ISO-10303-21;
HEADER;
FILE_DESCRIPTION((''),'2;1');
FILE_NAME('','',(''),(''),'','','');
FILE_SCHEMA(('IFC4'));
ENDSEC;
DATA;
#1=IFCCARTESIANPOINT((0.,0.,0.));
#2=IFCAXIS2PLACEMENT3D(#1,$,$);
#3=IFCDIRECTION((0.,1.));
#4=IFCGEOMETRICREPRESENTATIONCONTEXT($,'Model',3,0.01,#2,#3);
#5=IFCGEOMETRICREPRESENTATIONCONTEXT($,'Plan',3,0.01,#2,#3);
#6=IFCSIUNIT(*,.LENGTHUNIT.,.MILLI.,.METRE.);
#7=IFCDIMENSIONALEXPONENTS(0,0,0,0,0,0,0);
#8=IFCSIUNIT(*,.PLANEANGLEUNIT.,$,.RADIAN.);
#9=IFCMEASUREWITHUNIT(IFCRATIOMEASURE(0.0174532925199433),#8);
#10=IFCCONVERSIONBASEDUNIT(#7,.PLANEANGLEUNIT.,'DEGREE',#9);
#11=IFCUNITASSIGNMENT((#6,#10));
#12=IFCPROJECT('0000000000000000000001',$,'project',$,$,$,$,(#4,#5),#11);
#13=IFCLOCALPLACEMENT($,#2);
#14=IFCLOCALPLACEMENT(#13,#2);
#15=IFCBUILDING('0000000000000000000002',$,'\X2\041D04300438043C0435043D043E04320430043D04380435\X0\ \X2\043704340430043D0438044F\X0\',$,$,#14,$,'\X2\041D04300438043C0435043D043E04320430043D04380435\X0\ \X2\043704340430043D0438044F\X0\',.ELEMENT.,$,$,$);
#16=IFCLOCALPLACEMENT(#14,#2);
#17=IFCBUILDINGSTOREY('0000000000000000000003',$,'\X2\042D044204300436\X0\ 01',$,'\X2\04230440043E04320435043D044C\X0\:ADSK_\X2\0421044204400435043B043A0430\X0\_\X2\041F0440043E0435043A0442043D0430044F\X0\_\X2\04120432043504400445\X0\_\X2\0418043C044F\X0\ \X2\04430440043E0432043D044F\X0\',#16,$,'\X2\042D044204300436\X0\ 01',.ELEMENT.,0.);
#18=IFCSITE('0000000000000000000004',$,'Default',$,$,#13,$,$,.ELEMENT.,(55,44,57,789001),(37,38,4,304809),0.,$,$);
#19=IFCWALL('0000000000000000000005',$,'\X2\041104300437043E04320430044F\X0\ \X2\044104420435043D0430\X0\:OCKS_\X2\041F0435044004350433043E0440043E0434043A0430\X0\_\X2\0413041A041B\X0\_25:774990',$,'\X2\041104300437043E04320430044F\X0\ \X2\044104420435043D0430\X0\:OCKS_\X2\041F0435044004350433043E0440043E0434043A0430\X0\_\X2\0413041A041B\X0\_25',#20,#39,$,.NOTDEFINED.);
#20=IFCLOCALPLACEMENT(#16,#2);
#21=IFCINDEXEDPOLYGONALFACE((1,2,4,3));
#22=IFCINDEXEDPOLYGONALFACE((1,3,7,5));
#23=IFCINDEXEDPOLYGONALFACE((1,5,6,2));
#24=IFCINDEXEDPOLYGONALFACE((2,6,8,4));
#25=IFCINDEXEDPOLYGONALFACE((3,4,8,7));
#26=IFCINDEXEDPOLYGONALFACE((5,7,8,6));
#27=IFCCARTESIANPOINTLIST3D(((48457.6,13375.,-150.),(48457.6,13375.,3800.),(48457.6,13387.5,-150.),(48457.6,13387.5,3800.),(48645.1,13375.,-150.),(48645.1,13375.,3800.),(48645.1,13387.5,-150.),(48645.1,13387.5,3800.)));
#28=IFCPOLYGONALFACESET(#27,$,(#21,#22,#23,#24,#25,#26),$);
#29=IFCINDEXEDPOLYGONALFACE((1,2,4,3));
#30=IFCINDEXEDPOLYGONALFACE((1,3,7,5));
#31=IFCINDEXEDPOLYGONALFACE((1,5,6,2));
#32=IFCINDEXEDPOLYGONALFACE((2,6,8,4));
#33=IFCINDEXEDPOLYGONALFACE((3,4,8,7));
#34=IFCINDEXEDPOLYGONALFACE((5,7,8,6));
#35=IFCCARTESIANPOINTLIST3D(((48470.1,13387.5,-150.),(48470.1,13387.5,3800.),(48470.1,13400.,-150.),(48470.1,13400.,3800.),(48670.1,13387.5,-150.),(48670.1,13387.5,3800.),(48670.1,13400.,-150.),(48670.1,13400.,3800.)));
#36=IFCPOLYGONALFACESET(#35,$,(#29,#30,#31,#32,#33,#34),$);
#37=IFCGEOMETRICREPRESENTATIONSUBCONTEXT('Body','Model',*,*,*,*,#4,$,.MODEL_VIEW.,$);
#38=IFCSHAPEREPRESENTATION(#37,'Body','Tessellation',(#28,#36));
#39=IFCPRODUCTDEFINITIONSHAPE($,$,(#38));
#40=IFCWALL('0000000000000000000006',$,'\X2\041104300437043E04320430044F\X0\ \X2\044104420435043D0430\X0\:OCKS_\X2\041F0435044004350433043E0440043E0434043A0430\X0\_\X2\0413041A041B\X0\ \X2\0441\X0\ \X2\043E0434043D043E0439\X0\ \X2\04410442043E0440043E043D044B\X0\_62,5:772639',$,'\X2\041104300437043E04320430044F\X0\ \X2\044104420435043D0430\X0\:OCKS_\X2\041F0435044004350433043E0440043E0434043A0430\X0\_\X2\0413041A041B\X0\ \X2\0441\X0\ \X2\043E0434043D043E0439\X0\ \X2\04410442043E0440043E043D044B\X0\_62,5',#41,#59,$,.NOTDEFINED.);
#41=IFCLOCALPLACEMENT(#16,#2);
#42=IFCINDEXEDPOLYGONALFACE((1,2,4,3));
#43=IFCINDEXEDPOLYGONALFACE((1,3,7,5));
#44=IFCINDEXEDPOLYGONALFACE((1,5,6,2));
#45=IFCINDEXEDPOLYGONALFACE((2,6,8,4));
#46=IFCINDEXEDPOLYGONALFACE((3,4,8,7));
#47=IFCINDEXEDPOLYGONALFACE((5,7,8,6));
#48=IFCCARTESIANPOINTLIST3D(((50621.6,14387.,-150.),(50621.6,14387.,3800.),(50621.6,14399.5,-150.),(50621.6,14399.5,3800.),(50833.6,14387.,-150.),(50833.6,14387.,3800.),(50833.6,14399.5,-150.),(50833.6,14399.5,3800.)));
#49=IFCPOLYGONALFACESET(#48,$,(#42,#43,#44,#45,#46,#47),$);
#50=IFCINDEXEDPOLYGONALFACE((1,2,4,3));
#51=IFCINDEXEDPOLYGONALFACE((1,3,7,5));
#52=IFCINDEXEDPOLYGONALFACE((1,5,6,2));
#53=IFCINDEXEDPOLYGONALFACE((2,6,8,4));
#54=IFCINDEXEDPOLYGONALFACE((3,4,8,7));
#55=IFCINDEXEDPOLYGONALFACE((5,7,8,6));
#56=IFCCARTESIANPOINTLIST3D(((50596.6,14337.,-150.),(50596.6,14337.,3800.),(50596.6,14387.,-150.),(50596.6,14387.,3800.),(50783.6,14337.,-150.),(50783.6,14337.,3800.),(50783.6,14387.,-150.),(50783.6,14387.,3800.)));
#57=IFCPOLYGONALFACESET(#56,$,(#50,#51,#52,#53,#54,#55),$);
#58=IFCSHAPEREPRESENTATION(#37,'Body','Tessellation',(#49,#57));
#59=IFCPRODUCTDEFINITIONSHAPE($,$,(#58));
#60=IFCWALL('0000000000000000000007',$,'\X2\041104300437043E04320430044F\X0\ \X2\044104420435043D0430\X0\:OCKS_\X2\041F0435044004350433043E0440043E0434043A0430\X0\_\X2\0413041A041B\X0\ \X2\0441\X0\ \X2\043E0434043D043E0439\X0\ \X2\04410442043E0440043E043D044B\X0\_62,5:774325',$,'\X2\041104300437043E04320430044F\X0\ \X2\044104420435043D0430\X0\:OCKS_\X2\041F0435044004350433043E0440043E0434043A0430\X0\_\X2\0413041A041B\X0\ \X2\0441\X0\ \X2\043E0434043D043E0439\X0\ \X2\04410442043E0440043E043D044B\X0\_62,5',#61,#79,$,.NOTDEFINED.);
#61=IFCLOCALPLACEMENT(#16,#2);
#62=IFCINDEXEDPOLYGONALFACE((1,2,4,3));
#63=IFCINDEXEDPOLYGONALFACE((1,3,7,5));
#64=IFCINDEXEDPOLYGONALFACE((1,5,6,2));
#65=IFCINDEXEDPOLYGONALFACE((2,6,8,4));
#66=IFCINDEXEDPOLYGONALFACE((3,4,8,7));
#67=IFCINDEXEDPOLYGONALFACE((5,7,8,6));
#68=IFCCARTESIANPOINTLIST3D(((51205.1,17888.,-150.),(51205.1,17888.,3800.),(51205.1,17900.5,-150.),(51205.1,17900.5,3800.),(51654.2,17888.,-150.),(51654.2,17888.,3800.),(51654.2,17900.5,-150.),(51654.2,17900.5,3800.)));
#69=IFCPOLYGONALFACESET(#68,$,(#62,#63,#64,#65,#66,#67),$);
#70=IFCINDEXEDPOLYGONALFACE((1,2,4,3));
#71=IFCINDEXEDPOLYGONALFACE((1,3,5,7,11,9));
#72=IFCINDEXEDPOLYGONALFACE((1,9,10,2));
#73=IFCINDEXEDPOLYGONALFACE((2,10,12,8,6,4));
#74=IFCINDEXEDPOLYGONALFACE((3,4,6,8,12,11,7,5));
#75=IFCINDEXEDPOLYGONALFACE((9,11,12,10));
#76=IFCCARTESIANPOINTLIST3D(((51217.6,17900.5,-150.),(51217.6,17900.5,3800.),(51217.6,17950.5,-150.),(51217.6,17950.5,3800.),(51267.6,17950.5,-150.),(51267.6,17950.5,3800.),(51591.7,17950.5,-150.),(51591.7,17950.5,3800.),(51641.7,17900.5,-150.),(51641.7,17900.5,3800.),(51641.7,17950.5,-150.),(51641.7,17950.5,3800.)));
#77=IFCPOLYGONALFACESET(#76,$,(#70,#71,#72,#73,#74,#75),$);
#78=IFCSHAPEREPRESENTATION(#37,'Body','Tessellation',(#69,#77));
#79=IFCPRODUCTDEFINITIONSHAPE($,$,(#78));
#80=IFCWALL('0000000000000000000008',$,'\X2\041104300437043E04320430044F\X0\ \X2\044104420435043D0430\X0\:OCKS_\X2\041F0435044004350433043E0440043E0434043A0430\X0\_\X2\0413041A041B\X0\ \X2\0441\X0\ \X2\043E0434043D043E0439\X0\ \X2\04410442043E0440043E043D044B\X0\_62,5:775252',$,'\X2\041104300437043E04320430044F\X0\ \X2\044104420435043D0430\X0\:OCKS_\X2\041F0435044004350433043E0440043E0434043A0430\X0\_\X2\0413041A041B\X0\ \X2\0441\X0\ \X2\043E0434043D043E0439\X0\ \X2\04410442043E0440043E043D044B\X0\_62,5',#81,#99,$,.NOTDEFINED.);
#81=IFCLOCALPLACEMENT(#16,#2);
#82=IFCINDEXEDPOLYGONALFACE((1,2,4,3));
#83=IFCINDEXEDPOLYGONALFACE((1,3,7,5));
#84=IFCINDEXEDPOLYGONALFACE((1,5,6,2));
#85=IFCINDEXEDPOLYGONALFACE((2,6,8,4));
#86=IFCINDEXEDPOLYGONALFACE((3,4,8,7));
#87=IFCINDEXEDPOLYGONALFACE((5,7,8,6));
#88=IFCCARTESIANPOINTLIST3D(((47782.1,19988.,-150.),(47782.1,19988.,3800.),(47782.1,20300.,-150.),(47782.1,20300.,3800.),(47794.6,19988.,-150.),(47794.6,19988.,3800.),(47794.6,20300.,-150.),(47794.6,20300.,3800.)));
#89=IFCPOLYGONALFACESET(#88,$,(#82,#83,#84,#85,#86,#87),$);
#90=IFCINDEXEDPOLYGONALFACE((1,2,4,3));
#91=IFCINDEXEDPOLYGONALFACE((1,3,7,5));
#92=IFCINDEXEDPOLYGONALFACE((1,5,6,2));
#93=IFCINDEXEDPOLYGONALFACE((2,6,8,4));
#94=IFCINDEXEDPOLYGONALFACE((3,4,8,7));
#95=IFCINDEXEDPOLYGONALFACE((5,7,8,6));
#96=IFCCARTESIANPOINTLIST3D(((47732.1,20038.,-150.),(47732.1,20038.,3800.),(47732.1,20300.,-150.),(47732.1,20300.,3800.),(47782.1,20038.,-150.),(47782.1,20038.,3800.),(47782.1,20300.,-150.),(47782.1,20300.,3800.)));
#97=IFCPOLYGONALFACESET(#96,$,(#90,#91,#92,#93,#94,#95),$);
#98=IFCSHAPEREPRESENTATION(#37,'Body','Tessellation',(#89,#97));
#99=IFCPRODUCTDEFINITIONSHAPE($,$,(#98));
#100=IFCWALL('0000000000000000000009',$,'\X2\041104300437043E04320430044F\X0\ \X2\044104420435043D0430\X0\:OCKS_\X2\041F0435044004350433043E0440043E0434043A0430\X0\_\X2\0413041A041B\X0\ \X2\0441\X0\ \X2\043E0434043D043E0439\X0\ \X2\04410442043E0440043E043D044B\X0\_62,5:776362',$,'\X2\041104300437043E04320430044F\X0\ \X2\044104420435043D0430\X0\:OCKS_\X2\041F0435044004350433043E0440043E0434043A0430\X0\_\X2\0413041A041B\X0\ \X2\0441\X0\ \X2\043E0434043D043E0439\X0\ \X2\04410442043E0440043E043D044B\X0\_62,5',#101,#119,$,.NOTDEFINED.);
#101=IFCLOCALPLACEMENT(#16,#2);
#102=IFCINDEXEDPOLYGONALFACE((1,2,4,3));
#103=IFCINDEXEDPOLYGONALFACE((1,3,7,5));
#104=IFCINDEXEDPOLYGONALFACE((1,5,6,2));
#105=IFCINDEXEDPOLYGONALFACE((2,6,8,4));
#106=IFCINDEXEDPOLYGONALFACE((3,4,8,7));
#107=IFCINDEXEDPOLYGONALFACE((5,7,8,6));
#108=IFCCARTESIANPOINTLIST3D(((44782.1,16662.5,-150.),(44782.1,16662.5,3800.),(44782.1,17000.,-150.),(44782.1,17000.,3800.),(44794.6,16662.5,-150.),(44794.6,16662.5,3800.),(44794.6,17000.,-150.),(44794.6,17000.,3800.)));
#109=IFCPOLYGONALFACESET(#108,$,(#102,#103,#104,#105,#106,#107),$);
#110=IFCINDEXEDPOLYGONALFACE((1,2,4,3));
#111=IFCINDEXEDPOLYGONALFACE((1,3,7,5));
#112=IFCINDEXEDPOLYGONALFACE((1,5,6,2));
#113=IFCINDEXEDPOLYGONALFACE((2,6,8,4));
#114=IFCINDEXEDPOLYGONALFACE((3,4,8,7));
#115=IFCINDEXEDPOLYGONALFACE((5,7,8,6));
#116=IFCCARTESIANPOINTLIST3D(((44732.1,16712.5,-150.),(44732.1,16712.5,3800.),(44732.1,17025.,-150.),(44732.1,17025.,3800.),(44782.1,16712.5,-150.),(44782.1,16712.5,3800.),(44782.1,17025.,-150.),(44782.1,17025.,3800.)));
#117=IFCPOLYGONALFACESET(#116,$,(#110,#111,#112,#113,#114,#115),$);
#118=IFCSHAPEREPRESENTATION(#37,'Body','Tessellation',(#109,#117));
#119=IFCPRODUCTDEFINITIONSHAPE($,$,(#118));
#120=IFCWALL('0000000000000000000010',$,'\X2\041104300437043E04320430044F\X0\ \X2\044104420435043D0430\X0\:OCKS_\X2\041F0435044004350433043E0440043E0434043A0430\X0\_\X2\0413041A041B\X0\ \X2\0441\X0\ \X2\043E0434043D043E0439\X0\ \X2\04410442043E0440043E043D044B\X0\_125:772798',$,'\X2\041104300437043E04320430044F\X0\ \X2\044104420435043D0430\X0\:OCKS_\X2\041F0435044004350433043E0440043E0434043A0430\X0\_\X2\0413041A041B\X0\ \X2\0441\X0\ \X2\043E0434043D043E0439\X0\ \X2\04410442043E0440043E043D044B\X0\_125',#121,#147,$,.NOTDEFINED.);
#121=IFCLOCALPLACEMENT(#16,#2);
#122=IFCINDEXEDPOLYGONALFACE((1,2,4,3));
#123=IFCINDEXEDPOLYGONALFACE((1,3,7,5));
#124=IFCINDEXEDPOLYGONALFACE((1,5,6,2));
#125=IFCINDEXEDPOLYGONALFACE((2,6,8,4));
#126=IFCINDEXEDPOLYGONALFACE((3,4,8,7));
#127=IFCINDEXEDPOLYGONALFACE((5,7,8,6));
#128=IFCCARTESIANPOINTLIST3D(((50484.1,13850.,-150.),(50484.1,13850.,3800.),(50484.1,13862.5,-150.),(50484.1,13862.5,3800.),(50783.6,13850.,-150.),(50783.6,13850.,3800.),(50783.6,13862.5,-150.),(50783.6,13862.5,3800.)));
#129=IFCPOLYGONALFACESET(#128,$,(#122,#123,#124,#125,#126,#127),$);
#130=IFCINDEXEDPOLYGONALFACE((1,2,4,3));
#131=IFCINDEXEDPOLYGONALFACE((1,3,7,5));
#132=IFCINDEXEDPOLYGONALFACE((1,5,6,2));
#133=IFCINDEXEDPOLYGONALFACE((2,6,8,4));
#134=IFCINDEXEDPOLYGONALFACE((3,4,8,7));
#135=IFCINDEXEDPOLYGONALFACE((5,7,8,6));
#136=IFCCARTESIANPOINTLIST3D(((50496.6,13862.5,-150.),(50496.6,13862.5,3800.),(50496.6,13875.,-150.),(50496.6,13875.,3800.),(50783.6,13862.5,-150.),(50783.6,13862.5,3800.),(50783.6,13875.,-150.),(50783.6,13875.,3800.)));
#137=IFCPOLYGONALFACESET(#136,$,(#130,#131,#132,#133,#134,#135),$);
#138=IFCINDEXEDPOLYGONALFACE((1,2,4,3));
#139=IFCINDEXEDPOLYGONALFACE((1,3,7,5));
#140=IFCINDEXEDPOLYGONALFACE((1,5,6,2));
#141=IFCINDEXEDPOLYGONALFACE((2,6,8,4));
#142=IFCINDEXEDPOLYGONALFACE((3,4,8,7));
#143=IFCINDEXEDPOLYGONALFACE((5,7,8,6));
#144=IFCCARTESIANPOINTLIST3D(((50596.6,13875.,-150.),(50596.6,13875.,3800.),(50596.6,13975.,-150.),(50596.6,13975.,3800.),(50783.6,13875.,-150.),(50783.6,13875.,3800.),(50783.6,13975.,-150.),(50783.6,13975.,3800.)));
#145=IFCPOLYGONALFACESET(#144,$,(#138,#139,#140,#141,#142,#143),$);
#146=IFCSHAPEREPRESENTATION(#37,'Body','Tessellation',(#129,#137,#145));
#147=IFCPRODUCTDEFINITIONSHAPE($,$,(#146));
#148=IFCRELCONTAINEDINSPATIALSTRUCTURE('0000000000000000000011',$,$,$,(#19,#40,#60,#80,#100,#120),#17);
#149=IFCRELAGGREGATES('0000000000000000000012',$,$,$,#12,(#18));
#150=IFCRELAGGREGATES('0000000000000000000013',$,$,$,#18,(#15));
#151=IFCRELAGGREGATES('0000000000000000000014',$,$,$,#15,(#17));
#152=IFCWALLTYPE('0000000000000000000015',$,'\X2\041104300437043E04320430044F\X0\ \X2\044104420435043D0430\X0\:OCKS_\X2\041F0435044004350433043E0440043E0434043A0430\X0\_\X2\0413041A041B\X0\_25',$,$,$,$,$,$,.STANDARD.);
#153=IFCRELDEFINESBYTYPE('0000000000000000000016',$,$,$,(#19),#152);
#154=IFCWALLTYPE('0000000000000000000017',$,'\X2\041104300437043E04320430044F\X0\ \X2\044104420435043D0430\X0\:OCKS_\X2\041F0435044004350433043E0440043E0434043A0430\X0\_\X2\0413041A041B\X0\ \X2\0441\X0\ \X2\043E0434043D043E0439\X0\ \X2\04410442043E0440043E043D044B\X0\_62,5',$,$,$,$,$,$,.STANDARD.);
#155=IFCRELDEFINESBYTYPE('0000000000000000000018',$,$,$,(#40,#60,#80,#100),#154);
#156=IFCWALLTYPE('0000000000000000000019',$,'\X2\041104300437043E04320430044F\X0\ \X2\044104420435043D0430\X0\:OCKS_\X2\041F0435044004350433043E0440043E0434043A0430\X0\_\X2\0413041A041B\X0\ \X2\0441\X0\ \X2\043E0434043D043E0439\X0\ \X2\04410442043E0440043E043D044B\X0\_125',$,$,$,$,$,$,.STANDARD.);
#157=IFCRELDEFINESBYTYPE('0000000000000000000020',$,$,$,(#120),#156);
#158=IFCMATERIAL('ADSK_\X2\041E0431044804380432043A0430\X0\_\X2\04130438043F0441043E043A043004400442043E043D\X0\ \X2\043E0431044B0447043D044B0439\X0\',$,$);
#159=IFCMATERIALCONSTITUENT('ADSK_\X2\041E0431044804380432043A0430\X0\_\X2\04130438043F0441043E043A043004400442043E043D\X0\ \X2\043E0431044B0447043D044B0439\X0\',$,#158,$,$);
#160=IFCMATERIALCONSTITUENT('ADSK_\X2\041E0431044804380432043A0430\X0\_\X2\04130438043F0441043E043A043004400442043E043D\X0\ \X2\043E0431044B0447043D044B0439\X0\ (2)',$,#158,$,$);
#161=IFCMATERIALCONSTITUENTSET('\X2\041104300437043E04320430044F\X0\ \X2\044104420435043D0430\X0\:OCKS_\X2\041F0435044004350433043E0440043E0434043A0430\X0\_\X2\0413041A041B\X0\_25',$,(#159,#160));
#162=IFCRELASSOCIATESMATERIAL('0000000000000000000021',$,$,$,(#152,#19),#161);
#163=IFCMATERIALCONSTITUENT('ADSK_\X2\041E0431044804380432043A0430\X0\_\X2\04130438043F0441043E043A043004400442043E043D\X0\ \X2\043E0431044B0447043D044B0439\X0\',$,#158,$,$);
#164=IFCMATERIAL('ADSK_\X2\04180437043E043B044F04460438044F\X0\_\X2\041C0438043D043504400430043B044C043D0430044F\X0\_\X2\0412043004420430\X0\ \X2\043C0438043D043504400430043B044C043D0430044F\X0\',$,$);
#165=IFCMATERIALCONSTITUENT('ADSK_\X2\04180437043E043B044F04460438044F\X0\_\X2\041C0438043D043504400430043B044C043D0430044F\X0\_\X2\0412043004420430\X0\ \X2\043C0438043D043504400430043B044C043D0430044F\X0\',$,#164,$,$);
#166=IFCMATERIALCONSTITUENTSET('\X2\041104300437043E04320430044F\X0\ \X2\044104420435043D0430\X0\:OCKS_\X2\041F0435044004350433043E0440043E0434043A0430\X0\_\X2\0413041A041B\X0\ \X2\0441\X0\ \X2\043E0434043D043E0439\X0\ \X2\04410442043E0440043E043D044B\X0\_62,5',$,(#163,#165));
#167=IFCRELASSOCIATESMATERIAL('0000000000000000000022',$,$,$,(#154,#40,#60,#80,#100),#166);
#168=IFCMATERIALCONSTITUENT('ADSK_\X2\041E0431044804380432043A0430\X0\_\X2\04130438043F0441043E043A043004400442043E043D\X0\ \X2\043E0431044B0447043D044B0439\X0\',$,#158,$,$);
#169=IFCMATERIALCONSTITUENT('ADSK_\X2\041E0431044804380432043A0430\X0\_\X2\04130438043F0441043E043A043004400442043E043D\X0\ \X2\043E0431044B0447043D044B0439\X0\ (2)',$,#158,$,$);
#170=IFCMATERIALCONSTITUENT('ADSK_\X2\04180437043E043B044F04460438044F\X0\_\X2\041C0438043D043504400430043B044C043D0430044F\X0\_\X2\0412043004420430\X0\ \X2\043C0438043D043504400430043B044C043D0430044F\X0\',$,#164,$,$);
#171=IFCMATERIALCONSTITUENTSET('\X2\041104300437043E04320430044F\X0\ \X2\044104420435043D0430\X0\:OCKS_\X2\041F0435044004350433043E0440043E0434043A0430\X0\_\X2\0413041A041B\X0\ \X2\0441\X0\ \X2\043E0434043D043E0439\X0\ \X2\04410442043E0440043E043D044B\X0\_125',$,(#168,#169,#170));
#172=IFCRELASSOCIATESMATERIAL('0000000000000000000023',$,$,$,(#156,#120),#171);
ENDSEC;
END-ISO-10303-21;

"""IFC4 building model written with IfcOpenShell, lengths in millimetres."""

from ifc_helpers import new_model, entity, si_unit, converted_unit, direction, frame, origin, place, context, subcontext, project, spatial, indexed_curve, outline, extrude, material, constituent, constituent_set, type_object, element, save


model = new_model("IFC4")

# Units and contexts
model_context = context("Model", 3, precision=0.01, world=origin(), true_north=direction((0.0, 1.0)))
plan_context = context("Plan", 3, precision=0.01, world=origin(), true_north=direction((0.0, 1.0)))
body_context = subcontext(model_context, "Body", "Model", "MODEL_VIEW")
ifc_project = project(units=[si_unit("LENGTHUNIT", "METRE", prefix="MILLI"), converted_unit("PLANEANGLEUNIT", "DEGREE", entity("IfcRatioMeasure", 0.0174532925199433), si_unit("PLANEANGLEUNIT", "RADIAN"), dimensions=[0, 0, 0, 0, 0, 0, 0])], contexts=[model_context, plan_context])

# Site, building, storey
site_placement = place(None, frame((0.0, 0.0, 0.0)))
site = spatial("IfcSite", under=ifc_project, at=site_placement, Name="Default", CompositionType="ELEMENT", RefLatitude=(55, 44, 57, 789001), RefLongitude=(37, 38, 4, 304809), RefElevation=0.0)
building_placement = place(site_placement, origin())
building = spatial("IfcBuilding", under=site, at=building_placement, Name="Наименование здания", LongName="Наименование здания", CompositionType="ELEMENT")
storey_placement = place(building_placement, origin())
storey = spatial("IfcBuildingStorey", under=building, at=storey_placement, Name="Этаж 01", ObjectType="Уровень:ADSK_Стрелка_Проектная_Вверх_Имя уровня", LongName="Этаж 01", CompositionType="ELEMENT", Elevation=0.0)

# Shared definitions
ifc_material_1 = material(Name="ADSK_Обшивка_Гипсокартон обычный")
ifc_material_2 = material(Name="ADSK_Изоляция_Минеральная_Вата минеральная")

# Walls
ifc_constituent_1 = constituent(ifc_material_1, Name="ADSK_Обшивка_Гипсокартон обычный")
ifc_constituent_2 = constituent(ifc_material_1, Name="ADSK_Обшивка_Гипсокартон обычный (2)")
ifc_constituent_set_1 = constituent_set(constituents=[ifc_constituent_1, ifc_constituent_2], Name="Базовая стена:OCKS_Перегородка_ГКЛ_25")
wall_type_1 = type_object("IfcWallType", Name="Базовая стена:OCKS_Перегородка_ГКЛ_25", PredefinedType="STANDARD", material=ifc_constituent_set_1)
wall_1_placement = place(storey_placement, frame((48470.1, 13387.5, -150.0)))
element("IfcWall", 1, at=wall_1_placement, inside=storey, type_object=wall_type_1, material=ifc_constituent_set_1, Name="Базовая стена:OCKS_Перегородка_ГКЛ_25:774990", ObjectType="Базовая стена:OCKS_Перегородка_ГКЛ_25", PredefinedType="NOTDEFINED", context=body_context, shape_type="SweptSolid", body=[
    extrude(outline(indexed_curve([(-6.3, -93.8), (6.3, -93.8), (6.3, 93.8), (-6.3, 93.8), (-6.3, -93.8)], self_intersect=False)), frame((81.3, -6.3, 0.0), z_axis=(0.0, 0.0, 1.0), x_axis=(0.0, 1.0, 0.0)), (0.0, 0.0, 1.0), 3950.0),
    extrude(outline(indexed_curve([(-6.2, -100.0), (6.3, -100.0), (6.3, 100.0), (-6.2, 100.0), (-6.2, -100.0)], self_intersect=False)), frame((100.0, 6.3, 0.0), z_axis=(0.0, 0.0, 1.0), x_axis=(0.0, -1.0, 0.0)), (0.0, 0.0, 1.0), 3950.0),
])
ifc_constituent_3 = constituent(ifc_material_1, Name="ADSK_Обшивка_Гипсокартон обычный")
ifc_constituent_4 = constituent(ifc_material_2, Name="ADSK_Изоляция_Минеральная_Вата минеральная")
ifc_constituent_set_2 = constituent_set(constituents=[ifc_constituent_3, ifc_constituent_4], Name="Базовая стена:OCKS_Перегородка_ГКЛ с одной стороны_62,5")
wall_type_2 = type_object("IfcWallType", Name="Базовая стена:OCKS_Перегородка_ГКЛ с одной стороны_62,5", PredefinedType="STANDARD", material=ifc_constituent_set_2)
wall_2_placement = place(storey_placement, frame((50783.6, 14368.2, -150.0), z_axis=(0.0, 0.0, 1.0), x_axis=(-1.0, 0.0, 0.0)))
element("IfcWall", 2, at=wall_2_placement, inside=storey, type_object=wall_type_2, material=ifc_constituent_set_2, Name="Базовая стена:OCKS_Перегородка_ГКЛ с одной стороны_62,5:772639", ObjectType="Базовая стена:OCKS_Перегородка_ГКЛ с одной стороны_62,5", PredefinedType="NOTDEFINED", context=body_context, shape_type="SweptSolid", body=[
    extrude(outline(indexed_curve([(-6.3, -106.0), (6.3, -106.0), (6.3, 106.0), (-6.3, 106.0), (-6.3, -106.0)], self_intersect=False)), frame((56.0, -25.0, 0.0), z_axis=(0.0, 0.0, 1.0), x_axis=(0.0, 1.0, 0.0)), (0.0, 0.0, 1.0), 3950.0),
    extrude(outline(indexed_curve([(-25.0, -93.5), (25.0, -93.5), (25.0, 93.5), (-25.0, 93.5), (-25.0, -93.5)], self_intersect=False)), frame((93.5, 6.3, 0.0), z_axis=(0.0, 0.0, 1.0), x_axis=(0.0, -1.0, 0.0)), (0.0, 0.0, 1.0), 3950.0),
])
wall_3_placement = place(storey_placement, frame((51205.1, 17919.3, -150.0)))
element("IfcWall", 3, at=wall_3_placement, inside=storey, type_object=wall_type_2, material=ifc_constituent_set_2, Name="Базовая стена:OCKS_Перегородка_ГКЛ с одной стороны_62,5:774325", ObjectType="Базовая стена:OCKS_Перегородка_ГКЛ с одной стороны_62,5", PredefinedType="NOTDEFINED", context=body_context, shape_type="SweptSolid", body=[
    extrude(outline(indexed_curve([(-6.3, -224.5), (6.3, -224.5), (6.3, 224.5), (-6.2, 224.5), (-6.3, -224.5)], self_intersect=False)), frame((224.5, -25.0, 0.0), z_axis=(0.0, 0.0, 1.0), x_axis=(0.0, 1.0, 0.0)), (0.0, 0.0, 1.0), 3950.0),
    extrude(outline(indexed_curve([(-162.0, -16.7), (162.0, -16.7), (212.0, -16.7), (212.0, 33.3), (-212.0, 33.3), (-212.0, -16.7), (-162.0, -16.7)], self_intersect=False)), frame((224.5, 14.6, 0.0), z_axis=(0.0, 0.0, 1.0), x_axis=(-1.0, 0.0, 0.0)), (0.0, 0.0, 1.0), 3950.0),
])
wall_4_placement = place(storey_placement, frame((47763.4, 20038.0, -150.0), z_axis=(0.0, 0.0, 1.0), x_axis=(0.0, 1.0, 0.0)))
element("IfcWall", 4, at=wall_4_placement, inside=storey, type_object=wall_type_2, material=ifc_constituent_set_2, Name="Базовая стена:OCKS_Перегородка_ГКЛ с одной стороны_62,5:775252", ObjectType="Базовая стена:OCKS_Перегородка_ГКЛ с одной стороны_62,5", PredefinedType="NOTDEFINED", context=body_context, shape_type="SweptSolid", body=[
    extrude(outline(indexed_curve([(-6.3, -156.0), (6.3, -156.0), (6.3, 156.0), (-6.3, 156.0), (-6.3, -156.0)], self_intersect=False)), frame((106.0, -25.0, 0.0), z_axis=(0.0, 0.0, 1.0), x_axis=(0.0, 1.0, 0.0)), (0.0, 0.0, 1.0), 3950.0),
    extrude(outline(indexed_curve([(-25.0, -131.0), (25.0, -131.0), (25.0, 131.0), (-25.0, 131.0), (-25.0, -131.0)], self_intersect=False)), frame((131.0, 6.3, 0.0), z_axis=(0.0, 0.0, 1.0), x_axis=(0.0, -1.0, 0.0)), (0.0, 0.0, 1.0), 3950.0),
])
wall_5_placement = place(storey_placement, frame((44763.4, 16712.5, -150.0), z_axis=(0.0, 0.0, 1.0), x_axis=(0.0, 1.0, 0.0)))
element("IfcWall", 5, at=wall_5_placement, inside=storey, type_object=wall_type_2, material=ifc_constituent_set_2, Name="Базовая стена:OCKS_Перегородка_ГКЛ с одной стороны_62,5:776362", ObjectType="Базовая стена:OCKS_Перегородка_ГКЛ с одной стороны_62,5", PredefinedType="NOTDEFINED", context=body_context, shape_type="SweptSolid", body=[
    extrude(outline(indexed_curve([(-6.3, -168.8), (6.3, -168.8), (6.3, 168.8), (-6.3, 168.8), (-6.3, -168.8)], self_intersect=False)), frame((118.8, -25.0, 0.0), z_axis=(0.0, 0.0, 1.0), x_axis=(0.0, 1.0, 0.0)), (0.0, 0.0, 1.0), 3950.0),
    extrude(outline(indexed_curve([(-25.0, -156.3), (25.0, -156.3), (25.0, 156.3), (-25.0, 156.3), (-25.0, -156.3)], self_intersect=False)), frame((156.3, 6.2, 0.0), z_axis=(0.0, 0.0, 1.0), x_axis=(0.0, -1.0, 0.0)), (0.0, 0.0, 1.0), 3950.0),
])
ifc_constituent_5 = constituent(ifc_material_1, Name="ADSK_Обшивка_Гипсокартон обычный")
ifc_constituent_6 = constituent(ifc_material_1, Name="ADSK_Обшивка_Гипсокартон обычный (2)")
ifc_constituent_7 = constituent(ifc_material_2, Name="ADSK_Изоляция_Минеральная_Вата минеральная")
ifc_constituent_set_3 = constituent_set(constituents=[ifc_constituent_5, ifc_constituent_6, ifc_constituent_7], Name="Базовая стена:OCKS_Перегородка_ГКЛ с одной стороны_125")
wall_type_3 = type_object("IfcWallType", Name="Базовая стена:OCKS_Перегородка_ГКЛ с одной стороны_125", PredefinedType="STANDARD", material=ifc_constituent_set_3)
wall_6_placement = place(storey_placement, frame((50596.6, 13912.5, -150.0)))
element("IfcWall", 6, at=wall_6_placement, inside=storey, type_object=wall_type_3, material=ifc_constituent_set_3, Name="Базовая стена:OCKS_Перегородка_ГКЛ с одной стороны_125:772798", ObjectType="Базовая стена:OCKS_Перегородка_ГКЛ с одной стороны_125", PredefinedType="NOTDEFINED", context=body_context, shape_type="SweptSolid", body=[
    extrude(outline(indexed_curve([(-6.3, -149.8), (6.2, -149.8), (6.2, 149.8), (-6.3, 149.8), (-6.3, -149.8)], self_intersect=False)), frame((37.3, -56.2, 0.0), z_axis=(0.0, 0.0, 1.0), x_axis=(0.0, 1.0, 0.0)), (0.0, 0.0, 1.0), 3950.0),
    extrude(outline(indexed_curve([(-143.5, -6.3), (143.5, -6.3), (143.5, 6.2), (-143.5, 6.2), (-143.5, -6.3)], self_intersect=False)), frame((43.5, -43.7, 0.0)), (0.0, 0.0, 1.0), 3950.0),
    extrude(outline(indexed_curve([(-50.0, -93.5), (50.0, -93.5), (50.0, 93.5), (-50.0, 93.5), (-50.0, -93.5)], self_intersect=False)), frame((93.5, 12.5, 0.0), z_axis=(0.0, 0.0, 1.0), x_axis=(0.0, -1.0, 0.0)), (0.0, 0.0, 1.0), 3950.0),
])

save(model, "model.ifc")
